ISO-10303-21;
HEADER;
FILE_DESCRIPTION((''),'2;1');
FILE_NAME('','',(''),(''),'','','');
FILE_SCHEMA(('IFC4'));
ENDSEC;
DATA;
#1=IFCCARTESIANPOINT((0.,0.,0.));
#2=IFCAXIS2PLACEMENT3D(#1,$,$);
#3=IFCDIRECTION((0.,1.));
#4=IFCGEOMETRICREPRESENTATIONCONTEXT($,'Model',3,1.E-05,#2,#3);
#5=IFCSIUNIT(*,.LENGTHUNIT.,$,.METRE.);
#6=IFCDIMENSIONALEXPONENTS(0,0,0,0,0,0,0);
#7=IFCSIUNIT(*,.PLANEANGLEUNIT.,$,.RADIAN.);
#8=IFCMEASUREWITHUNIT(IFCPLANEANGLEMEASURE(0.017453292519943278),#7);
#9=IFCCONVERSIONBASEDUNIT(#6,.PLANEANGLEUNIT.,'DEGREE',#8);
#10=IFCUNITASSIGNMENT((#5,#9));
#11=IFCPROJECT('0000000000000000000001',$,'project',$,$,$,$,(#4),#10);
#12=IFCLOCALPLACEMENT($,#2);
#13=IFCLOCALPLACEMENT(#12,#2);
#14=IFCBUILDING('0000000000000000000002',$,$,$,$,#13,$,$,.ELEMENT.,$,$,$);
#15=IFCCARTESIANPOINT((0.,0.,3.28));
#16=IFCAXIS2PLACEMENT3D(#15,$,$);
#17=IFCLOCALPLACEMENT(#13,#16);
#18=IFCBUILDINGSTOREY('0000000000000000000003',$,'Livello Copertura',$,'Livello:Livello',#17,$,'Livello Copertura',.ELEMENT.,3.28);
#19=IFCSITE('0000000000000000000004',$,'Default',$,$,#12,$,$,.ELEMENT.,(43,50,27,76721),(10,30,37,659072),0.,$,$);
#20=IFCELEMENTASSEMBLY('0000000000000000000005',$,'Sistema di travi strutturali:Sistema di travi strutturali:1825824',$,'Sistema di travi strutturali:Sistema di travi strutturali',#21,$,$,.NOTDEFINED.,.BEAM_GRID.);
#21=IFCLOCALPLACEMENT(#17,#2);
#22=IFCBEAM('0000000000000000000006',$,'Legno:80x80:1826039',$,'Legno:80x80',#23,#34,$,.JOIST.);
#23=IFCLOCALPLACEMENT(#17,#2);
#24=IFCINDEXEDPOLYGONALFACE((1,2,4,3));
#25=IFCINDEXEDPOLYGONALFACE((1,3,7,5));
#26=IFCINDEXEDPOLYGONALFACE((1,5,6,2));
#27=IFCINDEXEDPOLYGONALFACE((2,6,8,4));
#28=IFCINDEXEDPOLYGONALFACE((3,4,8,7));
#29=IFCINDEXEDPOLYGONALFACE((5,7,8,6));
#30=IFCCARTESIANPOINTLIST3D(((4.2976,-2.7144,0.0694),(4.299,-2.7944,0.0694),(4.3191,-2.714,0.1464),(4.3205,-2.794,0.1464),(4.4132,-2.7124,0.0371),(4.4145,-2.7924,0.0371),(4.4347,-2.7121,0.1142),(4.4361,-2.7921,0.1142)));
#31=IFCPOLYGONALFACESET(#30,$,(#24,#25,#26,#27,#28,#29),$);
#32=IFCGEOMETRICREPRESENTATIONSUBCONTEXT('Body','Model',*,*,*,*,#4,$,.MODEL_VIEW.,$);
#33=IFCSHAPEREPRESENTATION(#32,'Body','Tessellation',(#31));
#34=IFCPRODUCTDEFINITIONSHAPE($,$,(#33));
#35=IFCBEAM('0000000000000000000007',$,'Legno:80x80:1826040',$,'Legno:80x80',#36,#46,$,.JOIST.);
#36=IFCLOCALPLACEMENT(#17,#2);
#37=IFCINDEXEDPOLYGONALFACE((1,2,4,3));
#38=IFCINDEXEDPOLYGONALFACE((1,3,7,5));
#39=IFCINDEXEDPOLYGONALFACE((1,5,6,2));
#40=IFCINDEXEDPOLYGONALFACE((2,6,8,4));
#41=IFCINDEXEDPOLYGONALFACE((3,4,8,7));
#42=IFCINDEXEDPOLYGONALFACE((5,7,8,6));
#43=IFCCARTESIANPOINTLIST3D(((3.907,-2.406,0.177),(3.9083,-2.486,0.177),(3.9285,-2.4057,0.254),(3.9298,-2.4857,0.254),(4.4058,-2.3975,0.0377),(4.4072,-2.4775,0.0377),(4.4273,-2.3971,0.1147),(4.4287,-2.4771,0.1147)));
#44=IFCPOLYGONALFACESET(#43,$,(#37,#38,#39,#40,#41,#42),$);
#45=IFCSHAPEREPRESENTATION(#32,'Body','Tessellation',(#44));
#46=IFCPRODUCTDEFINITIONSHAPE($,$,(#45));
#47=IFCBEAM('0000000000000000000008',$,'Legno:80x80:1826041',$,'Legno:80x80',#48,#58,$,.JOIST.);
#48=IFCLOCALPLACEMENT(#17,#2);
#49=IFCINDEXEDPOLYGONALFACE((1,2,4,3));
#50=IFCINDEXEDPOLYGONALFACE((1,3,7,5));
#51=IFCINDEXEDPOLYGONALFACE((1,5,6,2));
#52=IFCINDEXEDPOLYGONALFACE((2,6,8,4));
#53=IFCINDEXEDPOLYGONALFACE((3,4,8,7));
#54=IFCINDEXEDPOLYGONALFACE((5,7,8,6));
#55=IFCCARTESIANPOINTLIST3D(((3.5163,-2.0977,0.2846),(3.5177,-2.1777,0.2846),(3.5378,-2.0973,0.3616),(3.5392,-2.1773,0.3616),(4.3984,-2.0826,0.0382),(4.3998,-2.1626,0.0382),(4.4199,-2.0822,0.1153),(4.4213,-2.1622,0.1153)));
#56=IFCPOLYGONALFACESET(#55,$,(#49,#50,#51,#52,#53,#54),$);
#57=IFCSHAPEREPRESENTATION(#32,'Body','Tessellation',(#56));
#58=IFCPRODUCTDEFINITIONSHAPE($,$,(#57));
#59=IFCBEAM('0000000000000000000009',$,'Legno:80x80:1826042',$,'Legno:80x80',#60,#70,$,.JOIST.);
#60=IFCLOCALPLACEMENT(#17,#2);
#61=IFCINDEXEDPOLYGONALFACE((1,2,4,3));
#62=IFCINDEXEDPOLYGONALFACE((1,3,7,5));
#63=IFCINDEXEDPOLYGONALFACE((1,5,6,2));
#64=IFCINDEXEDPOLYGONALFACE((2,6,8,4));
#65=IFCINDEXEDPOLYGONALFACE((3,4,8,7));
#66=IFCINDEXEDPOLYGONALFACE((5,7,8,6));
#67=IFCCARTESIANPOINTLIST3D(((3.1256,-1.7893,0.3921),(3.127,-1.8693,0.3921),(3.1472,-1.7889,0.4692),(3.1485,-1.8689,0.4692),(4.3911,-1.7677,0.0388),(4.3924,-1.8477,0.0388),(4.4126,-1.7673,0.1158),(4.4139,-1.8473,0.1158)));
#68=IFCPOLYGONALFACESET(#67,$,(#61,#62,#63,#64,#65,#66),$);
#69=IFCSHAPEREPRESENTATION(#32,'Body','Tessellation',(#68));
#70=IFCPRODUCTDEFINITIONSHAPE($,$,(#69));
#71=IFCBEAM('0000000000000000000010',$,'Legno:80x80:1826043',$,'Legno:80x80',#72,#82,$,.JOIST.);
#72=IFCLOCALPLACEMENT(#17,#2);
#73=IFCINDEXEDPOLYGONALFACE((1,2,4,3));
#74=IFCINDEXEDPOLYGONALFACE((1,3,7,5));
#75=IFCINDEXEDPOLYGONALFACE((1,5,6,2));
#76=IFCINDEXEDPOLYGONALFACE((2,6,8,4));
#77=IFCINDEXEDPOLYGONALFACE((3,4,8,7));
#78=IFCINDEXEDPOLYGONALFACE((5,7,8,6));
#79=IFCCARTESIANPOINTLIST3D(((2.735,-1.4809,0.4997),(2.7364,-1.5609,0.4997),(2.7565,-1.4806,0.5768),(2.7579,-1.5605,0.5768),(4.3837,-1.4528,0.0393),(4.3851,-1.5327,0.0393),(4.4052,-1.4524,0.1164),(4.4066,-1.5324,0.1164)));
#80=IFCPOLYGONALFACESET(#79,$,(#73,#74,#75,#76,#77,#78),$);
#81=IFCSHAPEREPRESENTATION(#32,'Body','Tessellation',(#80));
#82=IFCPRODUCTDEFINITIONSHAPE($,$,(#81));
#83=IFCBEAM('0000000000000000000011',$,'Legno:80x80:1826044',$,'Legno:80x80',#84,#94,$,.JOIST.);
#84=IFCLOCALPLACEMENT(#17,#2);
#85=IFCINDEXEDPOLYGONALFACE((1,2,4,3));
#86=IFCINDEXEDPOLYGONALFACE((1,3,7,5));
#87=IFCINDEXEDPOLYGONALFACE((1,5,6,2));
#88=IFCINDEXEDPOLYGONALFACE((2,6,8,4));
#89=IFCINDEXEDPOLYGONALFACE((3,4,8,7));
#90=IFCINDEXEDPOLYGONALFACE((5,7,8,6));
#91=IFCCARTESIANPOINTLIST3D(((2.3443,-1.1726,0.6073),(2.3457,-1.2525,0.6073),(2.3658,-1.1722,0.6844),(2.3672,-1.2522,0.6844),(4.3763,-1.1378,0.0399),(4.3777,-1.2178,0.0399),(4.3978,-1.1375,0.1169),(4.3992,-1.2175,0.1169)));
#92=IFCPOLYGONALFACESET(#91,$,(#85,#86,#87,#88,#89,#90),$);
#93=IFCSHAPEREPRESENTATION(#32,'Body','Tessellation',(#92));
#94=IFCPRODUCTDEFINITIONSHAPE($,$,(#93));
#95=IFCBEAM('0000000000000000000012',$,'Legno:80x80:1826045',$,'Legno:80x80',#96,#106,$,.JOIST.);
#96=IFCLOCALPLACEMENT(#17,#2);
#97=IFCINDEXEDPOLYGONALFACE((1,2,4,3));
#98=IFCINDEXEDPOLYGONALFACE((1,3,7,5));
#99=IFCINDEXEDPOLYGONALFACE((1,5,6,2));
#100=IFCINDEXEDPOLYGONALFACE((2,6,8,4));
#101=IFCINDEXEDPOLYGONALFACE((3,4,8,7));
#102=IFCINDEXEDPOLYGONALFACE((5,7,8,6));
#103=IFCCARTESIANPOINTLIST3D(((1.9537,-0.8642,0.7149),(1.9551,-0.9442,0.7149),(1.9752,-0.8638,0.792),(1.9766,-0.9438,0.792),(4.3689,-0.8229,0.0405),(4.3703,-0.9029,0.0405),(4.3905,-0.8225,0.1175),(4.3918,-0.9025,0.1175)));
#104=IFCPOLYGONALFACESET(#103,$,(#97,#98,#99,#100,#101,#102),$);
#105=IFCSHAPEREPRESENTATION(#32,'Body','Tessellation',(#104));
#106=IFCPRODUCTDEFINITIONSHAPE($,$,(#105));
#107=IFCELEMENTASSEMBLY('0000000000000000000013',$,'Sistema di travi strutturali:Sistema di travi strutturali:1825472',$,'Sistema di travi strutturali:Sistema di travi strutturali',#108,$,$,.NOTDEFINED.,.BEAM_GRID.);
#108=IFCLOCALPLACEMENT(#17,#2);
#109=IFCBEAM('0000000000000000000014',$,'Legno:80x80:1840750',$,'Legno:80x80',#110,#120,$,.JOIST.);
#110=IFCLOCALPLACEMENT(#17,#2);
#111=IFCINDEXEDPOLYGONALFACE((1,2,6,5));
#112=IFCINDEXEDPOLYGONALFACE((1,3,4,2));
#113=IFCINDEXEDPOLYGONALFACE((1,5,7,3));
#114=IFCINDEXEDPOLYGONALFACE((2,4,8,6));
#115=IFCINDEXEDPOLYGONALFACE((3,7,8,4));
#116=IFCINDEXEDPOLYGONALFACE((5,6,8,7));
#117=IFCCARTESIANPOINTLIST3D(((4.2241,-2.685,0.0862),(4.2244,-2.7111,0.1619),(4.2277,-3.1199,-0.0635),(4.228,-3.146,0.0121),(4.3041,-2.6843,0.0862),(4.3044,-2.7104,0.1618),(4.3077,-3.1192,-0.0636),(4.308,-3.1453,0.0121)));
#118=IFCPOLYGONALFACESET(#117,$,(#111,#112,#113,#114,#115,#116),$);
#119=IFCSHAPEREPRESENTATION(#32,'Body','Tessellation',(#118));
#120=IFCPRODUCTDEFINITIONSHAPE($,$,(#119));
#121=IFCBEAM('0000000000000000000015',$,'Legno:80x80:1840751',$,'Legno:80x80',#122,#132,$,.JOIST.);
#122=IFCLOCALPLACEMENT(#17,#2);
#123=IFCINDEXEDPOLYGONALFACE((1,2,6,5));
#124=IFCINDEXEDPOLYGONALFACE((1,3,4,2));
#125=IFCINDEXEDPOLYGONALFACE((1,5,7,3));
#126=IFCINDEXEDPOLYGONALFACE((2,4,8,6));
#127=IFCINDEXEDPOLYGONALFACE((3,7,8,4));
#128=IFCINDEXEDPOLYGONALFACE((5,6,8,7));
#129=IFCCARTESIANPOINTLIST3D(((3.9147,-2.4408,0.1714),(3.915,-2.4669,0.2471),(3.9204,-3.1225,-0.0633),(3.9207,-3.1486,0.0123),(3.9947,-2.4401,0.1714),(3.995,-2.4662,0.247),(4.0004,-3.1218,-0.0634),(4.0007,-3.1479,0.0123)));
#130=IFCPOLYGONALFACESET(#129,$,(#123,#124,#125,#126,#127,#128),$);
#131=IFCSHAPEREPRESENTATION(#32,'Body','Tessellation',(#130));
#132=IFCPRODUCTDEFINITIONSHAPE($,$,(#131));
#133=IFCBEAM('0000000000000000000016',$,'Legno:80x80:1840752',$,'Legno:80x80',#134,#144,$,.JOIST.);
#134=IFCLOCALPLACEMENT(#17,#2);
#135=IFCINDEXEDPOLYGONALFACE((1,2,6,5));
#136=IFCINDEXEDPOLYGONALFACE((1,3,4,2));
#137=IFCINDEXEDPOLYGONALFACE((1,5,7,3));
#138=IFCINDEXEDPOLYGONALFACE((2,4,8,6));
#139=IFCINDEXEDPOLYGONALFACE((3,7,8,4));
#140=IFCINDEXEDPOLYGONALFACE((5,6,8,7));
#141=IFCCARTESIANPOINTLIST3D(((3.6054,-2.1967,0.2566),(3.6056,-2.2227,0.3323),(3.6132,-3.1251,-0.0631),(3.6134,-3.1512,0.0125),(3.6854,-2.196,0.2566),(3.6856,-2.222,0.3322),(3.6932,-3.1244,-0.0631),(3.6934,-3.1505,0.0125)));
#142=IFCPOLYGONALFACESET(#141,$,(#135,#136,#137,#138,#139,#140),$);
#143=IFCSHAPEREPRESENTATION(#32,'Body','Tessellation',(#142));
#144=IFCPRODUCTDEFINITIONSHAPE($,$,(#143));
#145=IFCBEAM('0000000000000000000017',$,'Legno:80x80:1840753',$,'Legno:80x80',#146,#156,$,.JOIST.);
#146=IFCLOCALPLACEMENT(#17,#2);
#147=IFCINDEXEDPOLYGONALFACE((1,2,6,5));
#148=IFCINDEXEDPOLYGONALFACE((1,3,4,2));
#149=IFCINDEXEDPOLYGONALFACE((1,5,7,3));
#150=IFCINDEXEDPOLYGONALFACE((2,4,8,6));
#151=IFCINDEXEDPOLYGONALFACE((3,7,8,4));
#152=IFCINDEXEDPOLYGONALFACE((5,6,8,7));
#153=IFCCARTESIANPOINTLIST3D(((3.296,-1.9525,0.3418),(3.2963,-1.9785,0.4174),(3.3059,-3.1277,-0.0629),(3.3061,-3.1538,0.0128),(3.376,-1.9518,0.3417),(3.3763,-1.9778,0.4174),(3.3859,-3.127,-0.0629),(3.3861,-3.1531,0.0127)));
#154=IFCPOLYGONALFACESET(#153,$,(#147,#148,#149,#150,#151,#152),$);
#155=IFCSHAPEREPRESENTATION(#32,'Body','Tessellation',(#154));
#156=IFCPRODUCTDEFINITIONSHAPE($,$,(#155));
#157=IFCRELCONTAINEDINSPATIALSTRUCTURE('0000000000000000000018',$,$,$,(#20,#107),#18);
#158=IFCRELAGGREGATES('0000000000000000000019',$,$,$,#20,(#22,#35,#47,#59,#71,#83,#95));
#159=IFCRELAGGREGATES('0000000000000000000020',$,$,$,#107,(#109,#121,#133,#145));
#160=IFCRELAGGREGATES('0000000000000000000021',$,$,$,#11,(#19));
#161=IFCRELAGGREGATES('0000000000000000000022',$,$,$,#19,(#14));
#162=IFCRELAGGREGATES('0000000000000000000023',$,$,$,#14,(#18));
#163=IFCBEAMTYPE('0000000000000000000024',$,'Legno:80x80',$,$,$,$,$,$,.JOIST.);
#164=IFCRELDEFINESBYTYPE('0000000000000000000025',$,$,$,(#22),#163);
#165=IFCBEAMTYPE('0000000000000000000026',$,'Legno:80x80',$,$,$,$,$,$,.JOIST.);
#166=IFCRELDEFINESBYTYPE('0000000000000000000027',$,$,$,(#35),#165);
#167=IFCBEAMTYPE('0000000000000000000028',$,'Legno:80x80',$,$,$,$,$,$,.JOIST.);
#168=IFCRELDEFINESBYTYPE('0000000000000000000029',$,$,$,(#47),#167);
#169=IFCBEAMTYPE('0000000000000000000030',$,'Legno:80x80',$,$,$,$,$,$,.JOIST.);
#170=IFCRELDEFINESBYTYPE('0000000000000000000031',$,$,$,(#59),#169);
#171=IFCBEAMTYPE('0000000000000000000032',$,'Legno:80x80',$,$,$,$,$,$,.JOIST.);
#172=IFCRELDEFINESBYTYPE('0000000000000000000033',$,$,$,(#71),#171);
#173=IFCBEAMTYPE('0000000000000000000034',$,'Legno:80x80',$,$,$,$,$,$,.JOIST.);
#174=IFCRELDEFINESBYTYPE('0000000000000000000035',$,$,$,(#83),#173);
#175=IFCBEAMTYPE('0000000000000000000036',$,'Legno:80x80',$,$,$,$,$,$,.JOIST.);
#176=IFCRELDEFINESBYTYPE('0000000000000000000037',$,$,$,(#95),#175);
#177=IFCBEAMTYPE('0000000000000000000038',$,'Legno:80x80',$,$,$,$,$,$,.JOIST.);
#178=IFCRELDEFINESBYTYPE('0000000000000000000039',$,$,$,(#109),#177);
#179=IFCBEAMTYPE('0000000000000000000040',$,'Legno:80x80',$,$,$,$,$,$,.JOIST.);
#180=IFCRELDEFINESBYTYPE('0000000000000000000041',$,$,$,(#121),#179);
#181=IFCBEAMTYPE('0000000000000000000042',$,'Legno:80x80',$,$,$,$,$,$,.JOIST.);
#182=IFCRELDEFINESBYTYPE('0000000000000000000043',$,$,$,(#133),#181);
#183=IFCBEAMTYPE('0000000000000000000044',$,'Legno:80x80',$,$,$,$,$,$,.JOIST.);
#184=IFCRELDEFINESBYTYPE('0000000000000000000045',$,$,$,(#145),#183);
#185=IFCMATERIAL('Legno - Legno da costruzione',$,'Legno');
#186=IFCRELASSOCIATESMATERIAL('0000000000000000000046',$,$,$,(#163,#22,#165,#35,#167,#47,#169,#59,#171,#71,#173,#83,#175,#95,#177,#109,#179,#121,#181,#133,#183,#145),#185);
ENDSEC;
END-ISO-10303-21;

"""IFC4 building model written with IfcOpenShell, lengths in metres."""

from ifc_helpers import new_model, entity, si_unit, converted_unit, direction, frame, origin, place, context, subcontext, project, spatial, indexed_curve, outline, extrude, source, transform, mapped, material, type_object, type_shapes, element, aggregate, save


model = new_model("IFC4")

# Units and contexts
model_context = context("Model", 3, precision=1e-05, world=origin(), true_north=direction((0.0, 1.0)))
body_context = subcontext(model_context, "Body", "Model", "MODEL_VIEW")
ifc_project = project(units=[si_unit("LENGTHUNIT", "METRE"), converted_unit("PLANEANGLEUNIT", "DEGREE", entity("IfcPlaneAngleMeasure", 0.017453292519943278), si_unit("PLANEANGLEUNIT", "RADIAN"), dimensions=[0, 0, 0, 0, 0, 0, 0])], contexts=[model_context])

# Site, building, storey
site_placement = place(None, origin())
site = spatial("IfcSite", under=ifc_project, at=site_placement, Name="Default", CompositionType="ELEMENT", RefLatitude=(43, 50, 27, 76721), RefLongitude=(10, 30, 37, 659072), RefElevation=0.0)
building_placement = place(site_placement, origin())
building = spatial("IfcBuilding", under=site, at=building_placement, CompositionType="ELEMENT")
storey_placement = place(building_placement, frame((0.0, 0.0, 3.28)))
storey = spatial("IfcBuildingStorey", under=building, at=storey_placement, Name="Livello Copertura", ObjectType="Livello:Livello", LongName="Livello Copertura", CompositionType="ELEMENT", Elevation=3.28)

# Element assemblies, beams
assembly_1_placement = place(storey_placement, origin())
assembly_1 = element("IfcElementAssembly", 1, at=assembly_1_placement, inside=storey, Name="Sistema di travi strutturali:Sistema di travi strutturali:1825824", ObjectType="Sistema di travi strutturali:Sistema di travi strutturali", AssemblyPlace="NOTDEFINED", PredefinedType="BEAM_GRID")
ifc_material = material(Name="Legno - Legno da costruzione", Category="Legno")
beam_type_1 = type_object("IfcBeamType", Name="Legno:80x80", PredefinedType="JOIST", material=ifc_material)
shared_shape_1 = source(origin(), body_context, "Body", "SweptSolid", [
    extrude(outline(indexed_curve([(-0.06, -0.04), (0.06, -0.04), (0.06, 0.04), (-0.06, 0.04), (-0.06, -0.04)], self_intersect=False)), frame((0.0, 0.0, -0.04), z_axis=(0.0, 0.0, 1.0), x_axis=(-1.0, 0.0, 0.0)), (0.0, 0.0, 1.0), 0.08),
])
type_shapes(beam_type_1, [shared_shape_1])
beam_1_placement = place(assembly_1_placement, frame((4.3668, -2.7532, 0.0918), z_axis=(0.268881, 0.004594, 0.963163), x_axis=(-0.963022, -0.016456, 0.26892)))
beam_1 = element("IfcBeam", 2, at=beam_1_placement, type_object=beam_type_1, material=ifc_material, Name="Legno:80x80:1826039", ObjectType="Legno:80x80", PredefinedType="JOIST", context=body_context, shape_type="MappedRepresentation", body=[
    mapped(shared_shape_1, transform((0.0, 0.0, 0.0), scale=1.0)),
])
beam_type_2 = type_object("IfcBeamType", Name="Legno:80x80", PredefinedType="JOIST", material=ifc_material)
shared_shape_2 = source(origin(), body_context, "Body", "SweptSolid", [
    extrude(outline(indexed_curve([(-0.259, -0.04), (0.259, -0.04), (0.259, 0.04), (-0.259, 0.04), (-0.259, -0.04)], self_intersect=False)), frame((0.0, 0.0, -0.04), z_axis=(0.0, 0.0, 1.0), x_axis=(-1.0, 0.0, 0.0)), (0.0, 0.0, 1.0), 0.08),
])
type_shapes(beam_type_2, [shared_shape_2])
beam_2_placement = place(assembly_1_placement, frame((4.1678, -2.4416, 0.1459), z_axis=(0.268881, 0.004594, 0.963163), x_axis=(-0.963022, -0.016456, 0.26892)))
beam_2 = element("IfcBeam", 3, at=beam_2_placement, type_object=beam_type_2, material=ifc_material, Name="Legno:80x80:1826040", ObjectType="Legno:80x80", PredefinedType="JOIST", context=body_context, shape_type="MappedRepresentation", body=[
    mapped(shared_shape_2, transform((0.0, 0.0, 0.0), scale=1.0)),
])
beam_type_3 = type_object("IfcBeamType", Name="Legno:80x80", PredefinedType="JOIST", material=ifc_material)
shared_shape_3 = source(origin(), body_context, "Body", "SweptSolid", [
    extrude(outline(indexed_curve([(-0.458, -0.04), (0.458, -0.04), (0.458, 0.04), (-0.458, 0.04), (-0.458, -0.04)], self_intersect=False)), frame((0.0, 0.0, -0.04), z_axis=(0.0, 0.0, 1.0), x_axis=(-1.0, 0.0, 0.0)), (0.0, 0.0, 1.0), 0.08),
])
type_shapes(beam_type_3, [shared_shape_3])
beam_3_placement = place(assembly_1_placement, frame((3.9688, -2.1299, 0.1999), z_axis=(0.268881, 0.004594, 0.963163), x_axis=(-0.963022, -0.016456, 0.26892)))
beam_3 = element("IfcBeam", 4, at=beam_3_placement, type_object=beam_type_3, material=ifc_material, Name="Legno:80x80:1826041", ObjectType="Legno:80x80", PredefinedType="JOIST", context=body_context, shape_type="MappedRepresentation", body=[
    mapped(shared_shape_3, transform((0.0, 0.0, 0.0), scale=1.0)),
])
beam_type_4 = type_object("IfcBeamType", Name="Legno:80x80", PredefinedType="JOIST", material=ifc_material)
shared_shape_4 = source(origin(), body_context, "Body", "SweptSolid", [
    extrude(outline(indexed_curve([(-0.657, -0.04), (0.657, -0.04), (0.657, 0.04), (-0.657, 0.04), (-0.657, -0.04)], self_intersect=False)), frame((0.0, 0.0, -0.04), z_axis=(0.0, 0.0, 1.0), x_axis=(-1.0, 0.0, 0.0)), (0.0, 0.0, 1.0), 0.08),
])
type_shapes(beam_type_4, [shared_shape_4])
beam_4_placement = place(assembly_1_placement, frame((3.7698, -1.8183, 0.254), z_axis=(0.268881, 0.004594, 0.963163), x_axis=(-0.963022, -0.016456, 0.26892)))
beam_4 = element("IfcBeam", 5, at=beam_4_placement, type_object=beam_type_4, material=ifc_material, Name="Legno:80x80:1826042", ObjectType="Legno:80x80", PredefinedType="JOIST", context=body_context, shape_type="MappedRepresentation", body=[
    mapped(shared_shape_4, transform((0.0, 0.0, 0.0), scale=1.0)),
])
beam_type_5 = type_object("IfcBeamType", Name="Legno:80x80", PredefinedType="JOIST", material=ifc_material)
shared_shape_5 = source(origin(), body_context, "Body", "SweptSolid", [
    extrude(outline(indexed_curve([(-0.856, -0.04), (0.856, -0.04), (0.856, 0.04), (-0.856, 0.04), (-0.856, -0.04)], self_intersect=False)), frame((0.0, 0.0, -0.04), z_axis=(0.0, 0.0, 1.0), x_axis=(-1.0, 0.0, 0.0)), (0.0, 0.0, 1.0), 0.08),
])
type_shapes(beam_type_5, [shared_shape_5])
beam_5_placement = place(assembly_1_placement, frame((3.5708, -1.5066, 0.3081), z_axis=(0.268881, 0.004594, 0.963163), x_axis=(-0.963022, -0.016456, 0.26892)))
beam_5 = element("IfcBeam", 6, at=beam_5_placement, type_object=beam_type_5, material=ifc_material, Name="Legno:80x80:1826043", ObjectType="Legno:80x80", PredefinedType="JOIST", context=body_context, shape_type="MappedRepresentation", body=[
    mapped(shared_shape_5, transform((0.0, 0.0, 0.0), scale=1.0)),
])
beam_type_6 = type_object("IfcBeamType", Name="Legno:80x80", PredefinedType="JOIST", material=ifc_material)
shared_shape_6 = source(origin(), body_context, "Body", "SweptSolid", [
    extrude(outline(indexed_curve([(-1.055, -0.04), (1.055, -0.04), (1.055, 0.04), (-1.055, 0.04), (-1.055, -0.04)], self_intersect=False)), frame((0.0, 0.0, -0.04), z_axis=(0.0, 0.0, 1.0), x_axis=(-1.0, 0.0, 0.0)), (0.0, 0.0, 1.0), 0.08),
])
type_shapes(beam_type_6, [shared_shape_6])
beam_6_placement = place(assembly_1_placement, frame((3.3718, -1.195, 0.3621), z_axis=(0.268881, 0.004594, 0.963163), x_axis=(-0.963022, -0.016456, 0.26892)))
beam_6 = element("IfcBeam", 7, at=beam_6_placement, type_object=beam_type_6, material=ifc_material, Name="Legno:80x80:1826044", ObjectType="Legno:80x80", PredefinedType="JOIST", context=body_context, shape_type="MappedRepresentation", body=[
    mapped(shared_shape_6, transform((0.0, 0.0, 0.0), scale=1.0)),
])
beam_type_7 = type_object("IfcBeamType", Name="Legno:80x80", PredefinedType="JOIST", material=ifc_material)
shared_shape_7 = source(origin(), body_context, "Body", "SweptSolid", [
    extrude(outline(indexed_curve([(-1.254, -0.04), (1.254, -0.04), (1.254, 0.04), (-1.254, 0.04), (-1.254, -0.04)], self_intersect=False)), frame((0.0, 0.0, -0.04), z_axis=(0.0, 0.0, 1.0), x_axis=(-1.0, 0.0, 0.0)), (0.0, 0.0, 1.0), 0.08),
])
type_shapes(beam_type_7, [shared_shape_7])
beam_7_placement = place(assembly_1_placement, frame((3.1728, -0.8834, 0.4162), z_axis=(0.268881, 0.004594, 0.963163), x_axis=(-0.963022, -0.016456, 0.26892)))
beam_7 = element("IfcBeam", 8, at=beam_7_placement, type_object=beam_type_7, material=ifc_material, Name="Legno:80x80:1826045", ObjectType="Legno:80x80", PredefinedType="JOIST", context=body_context, shape_type="MappedRepresentation", body=[
    mapped(shared_shape_7, transform((0.0, 0.0, 0.0), scale=1.0)),
])
aggregate(assembly_1, [beam_1, beam_2, beam_3, beam_4, beam_5, beam_6, beam_7])
assembly_2_placement = place(storey_placement, origin())
assembly_2 = element("IfcElementAssembly", 9, at=assembly_2_placement, inside=storey, Name="Sistema di travi strutturali:Sistema di travi strutturali:1825472", ObjectType="Sistema di travi strutturali:Sistema di travi strutturali", AssemblyPlace="NOTDEFINED", PredefinedType="BEAM_GRID")
beam_type_8 = type_object("IfcBeamType", Name="Legno:80x80", PredefinedType="JOIST", material=ifc_material)
shared_shape_8 = source(origin(), body_context, "Body", "SweptSolid", [
    extrude(outline(indexed_curve([(-0.23, -0.04), (0.23, -0.04), (0.23, 0.04), (-0.23, 0.04), (-0.23, -0.04)], self_intersect=False)), frame((0.0, 0.0, -0.04), z_axis=(0.0, 0.0, 1.0), x_axis=(-1.0, 0.0, 0.0)), (0.0, 0.0, 1.0), 0.08),
])
type_shapes(beam_type_8, [shared_shape_8])
beam_8_placement = place(assembly_2_placement, frame((4.266, -2.9151, 0.0492), z_axis=(0.003393, -0.32555, 0.945519), x_axis=(-0.007932, 0.945486, 0.325568)))
beam_8 = element("IfcBeam", 10, at=beam_8_placement, type_object=beam_type_8, material=ifc_material, Name="Legno:80x80:1840750", ObjectType="Legno:80x80", PredefinedType="JOIST", context=body_context, shape_type="MappedRepresentation", body=[
    mapped(shared_shape_8, transform((0.0, 0.0, 0.0), scale=1.0)),
])
beam_type_9 = type_object("IfcBeamType", Name="Legno:80x80", PredefinedType="JOIST", material=ifc_material)
shared_shape_9 = source(origin(), body_context, "Body", "SweptSolid", [
    extrude(outline(indexed_curve([(-0.3605, -0.04), (0.3605, -0.04), (0.3605, 0.04), (-0.3605, 0.04), (-0.3605, -0.04)], self_intersect=False)), frame((0.0, 0.0, -0.04), z_axis=(0.0, 0.0, 1.0), x_axis=(-1.0, 0.0, 0.0)), (0.0, 0.0, 1.0), 0.08),
])
type_shapes(beam_type_9, [shared_shape_9])
beam_9_placement = place(assembly_2_placement, frame((3.9577, -2.7944, 0.0919), z_axis=(0.003393, -0.32555, 0.945519), x_axis=(-0.007932, 0.945486, 0.325568)))
beam_9 = element("IfcBeam", 11, at=beam_9_placement, type_object=beam_type_9, material=ifc_material, Name="Legno:80x80:1840751", ObjectType="Legno:80x80", PredefinedType="JOIST", context=body_context, shape_type="MappedRepresentation", body=[
    mapped(shared_shape_9, transform((0.0, 0.0, 0.0), scale=1.0)),
])
beam_type_10 = type_object("IfcBeamType", Name="Legno:80x80", PredefinedType="JOIST", material=ifc_material)
shared_shape_10 = source(origin(), body_context, "Body", "SweptSolid", [
    extrude(outline(indexed_curve([(-0.491, -0.04), (0.491, -0.04), (0.491, 0.04), (-0.491, 0.04), (-0.491, -0.04)], self_intersect=False)), frame((0.0, 0.0, -0.04), z_axis=(0.0, 0.0, 1.0), x_axis=(-1.0, 0.0, 0.0)), (0.0, 0.0, 1.0), 0.08),
])
type_shapes(beam_type_10, [shared_shape_10])
beam_10_placement = place(assembly_2_placement, frame((3.6494, -2.6736, 0.1346), z_axis=(0.003393, -0.32555, 0.945519), x_axis=(-0.007932, 0.945486, 0.325568)))
beam_10 = element("IfcBeam", 12, at=beam_10_placement, type_object=beam_type_10, material=ifc_material, Name="Legno:80x80:1840752", ObjectType="Legno:80x80", PredefinedType="JOIST", context=body_context, shape_type="MappedRepresentation", body=[
    mapped(shared_shape_10, transform((0.0, 0.0, 0.0), scale=1.0)),
])
beam_type_11 = type_object("IfcBeamType", Name="Legno:80x80", PredefinedType="JOIST", material=ifc_material)
shared_shape_11 = source(origin(), body_context, "Body", "SweptSolid", [
    extrude(outline(indexed_curve([(-0.6215, -0.04), (0.6215, -0.04), (0.6215, 0.04), (-0.6215, 0.04), (-0.6215, -0.04)], self_intersect=False)), frame((0.0, 0.0, -0.04), z_axis=(0.0, 0.0, 1.0), x_axis=(-1.0, 0.0, 0.0)), (0.0, 0.0, 1.0), 0.08),
])
type_shapes(beam_type_11, [shared_shape_11])
beam_11_placement = place(assembly_2_placement, frame((3.3411, -2.5528, 0.1772), z_axis=(0.003393, -0.32555, 0.945519), x_axis=(-0.007932, 0.945486, 0.325568)))
beam_11 = element("IfcBeam", 13, at=beam_11_placement, type_object=beam_type_11, material=ifc_material, Name="Legno:80x80:1840753", ObjectType="Legno:80x80", PredefinedType="JOIST", context=body_context, shape_type="MappedRepresentation", body=[
    mapped(shared_shape_11, transform((0.0, 0.0, 0.0), scale=1.0)),
])
aggregate(assembly_2, [beam_8, beam_9, beam_10, beam_11])

save(model, "model.ifc")
